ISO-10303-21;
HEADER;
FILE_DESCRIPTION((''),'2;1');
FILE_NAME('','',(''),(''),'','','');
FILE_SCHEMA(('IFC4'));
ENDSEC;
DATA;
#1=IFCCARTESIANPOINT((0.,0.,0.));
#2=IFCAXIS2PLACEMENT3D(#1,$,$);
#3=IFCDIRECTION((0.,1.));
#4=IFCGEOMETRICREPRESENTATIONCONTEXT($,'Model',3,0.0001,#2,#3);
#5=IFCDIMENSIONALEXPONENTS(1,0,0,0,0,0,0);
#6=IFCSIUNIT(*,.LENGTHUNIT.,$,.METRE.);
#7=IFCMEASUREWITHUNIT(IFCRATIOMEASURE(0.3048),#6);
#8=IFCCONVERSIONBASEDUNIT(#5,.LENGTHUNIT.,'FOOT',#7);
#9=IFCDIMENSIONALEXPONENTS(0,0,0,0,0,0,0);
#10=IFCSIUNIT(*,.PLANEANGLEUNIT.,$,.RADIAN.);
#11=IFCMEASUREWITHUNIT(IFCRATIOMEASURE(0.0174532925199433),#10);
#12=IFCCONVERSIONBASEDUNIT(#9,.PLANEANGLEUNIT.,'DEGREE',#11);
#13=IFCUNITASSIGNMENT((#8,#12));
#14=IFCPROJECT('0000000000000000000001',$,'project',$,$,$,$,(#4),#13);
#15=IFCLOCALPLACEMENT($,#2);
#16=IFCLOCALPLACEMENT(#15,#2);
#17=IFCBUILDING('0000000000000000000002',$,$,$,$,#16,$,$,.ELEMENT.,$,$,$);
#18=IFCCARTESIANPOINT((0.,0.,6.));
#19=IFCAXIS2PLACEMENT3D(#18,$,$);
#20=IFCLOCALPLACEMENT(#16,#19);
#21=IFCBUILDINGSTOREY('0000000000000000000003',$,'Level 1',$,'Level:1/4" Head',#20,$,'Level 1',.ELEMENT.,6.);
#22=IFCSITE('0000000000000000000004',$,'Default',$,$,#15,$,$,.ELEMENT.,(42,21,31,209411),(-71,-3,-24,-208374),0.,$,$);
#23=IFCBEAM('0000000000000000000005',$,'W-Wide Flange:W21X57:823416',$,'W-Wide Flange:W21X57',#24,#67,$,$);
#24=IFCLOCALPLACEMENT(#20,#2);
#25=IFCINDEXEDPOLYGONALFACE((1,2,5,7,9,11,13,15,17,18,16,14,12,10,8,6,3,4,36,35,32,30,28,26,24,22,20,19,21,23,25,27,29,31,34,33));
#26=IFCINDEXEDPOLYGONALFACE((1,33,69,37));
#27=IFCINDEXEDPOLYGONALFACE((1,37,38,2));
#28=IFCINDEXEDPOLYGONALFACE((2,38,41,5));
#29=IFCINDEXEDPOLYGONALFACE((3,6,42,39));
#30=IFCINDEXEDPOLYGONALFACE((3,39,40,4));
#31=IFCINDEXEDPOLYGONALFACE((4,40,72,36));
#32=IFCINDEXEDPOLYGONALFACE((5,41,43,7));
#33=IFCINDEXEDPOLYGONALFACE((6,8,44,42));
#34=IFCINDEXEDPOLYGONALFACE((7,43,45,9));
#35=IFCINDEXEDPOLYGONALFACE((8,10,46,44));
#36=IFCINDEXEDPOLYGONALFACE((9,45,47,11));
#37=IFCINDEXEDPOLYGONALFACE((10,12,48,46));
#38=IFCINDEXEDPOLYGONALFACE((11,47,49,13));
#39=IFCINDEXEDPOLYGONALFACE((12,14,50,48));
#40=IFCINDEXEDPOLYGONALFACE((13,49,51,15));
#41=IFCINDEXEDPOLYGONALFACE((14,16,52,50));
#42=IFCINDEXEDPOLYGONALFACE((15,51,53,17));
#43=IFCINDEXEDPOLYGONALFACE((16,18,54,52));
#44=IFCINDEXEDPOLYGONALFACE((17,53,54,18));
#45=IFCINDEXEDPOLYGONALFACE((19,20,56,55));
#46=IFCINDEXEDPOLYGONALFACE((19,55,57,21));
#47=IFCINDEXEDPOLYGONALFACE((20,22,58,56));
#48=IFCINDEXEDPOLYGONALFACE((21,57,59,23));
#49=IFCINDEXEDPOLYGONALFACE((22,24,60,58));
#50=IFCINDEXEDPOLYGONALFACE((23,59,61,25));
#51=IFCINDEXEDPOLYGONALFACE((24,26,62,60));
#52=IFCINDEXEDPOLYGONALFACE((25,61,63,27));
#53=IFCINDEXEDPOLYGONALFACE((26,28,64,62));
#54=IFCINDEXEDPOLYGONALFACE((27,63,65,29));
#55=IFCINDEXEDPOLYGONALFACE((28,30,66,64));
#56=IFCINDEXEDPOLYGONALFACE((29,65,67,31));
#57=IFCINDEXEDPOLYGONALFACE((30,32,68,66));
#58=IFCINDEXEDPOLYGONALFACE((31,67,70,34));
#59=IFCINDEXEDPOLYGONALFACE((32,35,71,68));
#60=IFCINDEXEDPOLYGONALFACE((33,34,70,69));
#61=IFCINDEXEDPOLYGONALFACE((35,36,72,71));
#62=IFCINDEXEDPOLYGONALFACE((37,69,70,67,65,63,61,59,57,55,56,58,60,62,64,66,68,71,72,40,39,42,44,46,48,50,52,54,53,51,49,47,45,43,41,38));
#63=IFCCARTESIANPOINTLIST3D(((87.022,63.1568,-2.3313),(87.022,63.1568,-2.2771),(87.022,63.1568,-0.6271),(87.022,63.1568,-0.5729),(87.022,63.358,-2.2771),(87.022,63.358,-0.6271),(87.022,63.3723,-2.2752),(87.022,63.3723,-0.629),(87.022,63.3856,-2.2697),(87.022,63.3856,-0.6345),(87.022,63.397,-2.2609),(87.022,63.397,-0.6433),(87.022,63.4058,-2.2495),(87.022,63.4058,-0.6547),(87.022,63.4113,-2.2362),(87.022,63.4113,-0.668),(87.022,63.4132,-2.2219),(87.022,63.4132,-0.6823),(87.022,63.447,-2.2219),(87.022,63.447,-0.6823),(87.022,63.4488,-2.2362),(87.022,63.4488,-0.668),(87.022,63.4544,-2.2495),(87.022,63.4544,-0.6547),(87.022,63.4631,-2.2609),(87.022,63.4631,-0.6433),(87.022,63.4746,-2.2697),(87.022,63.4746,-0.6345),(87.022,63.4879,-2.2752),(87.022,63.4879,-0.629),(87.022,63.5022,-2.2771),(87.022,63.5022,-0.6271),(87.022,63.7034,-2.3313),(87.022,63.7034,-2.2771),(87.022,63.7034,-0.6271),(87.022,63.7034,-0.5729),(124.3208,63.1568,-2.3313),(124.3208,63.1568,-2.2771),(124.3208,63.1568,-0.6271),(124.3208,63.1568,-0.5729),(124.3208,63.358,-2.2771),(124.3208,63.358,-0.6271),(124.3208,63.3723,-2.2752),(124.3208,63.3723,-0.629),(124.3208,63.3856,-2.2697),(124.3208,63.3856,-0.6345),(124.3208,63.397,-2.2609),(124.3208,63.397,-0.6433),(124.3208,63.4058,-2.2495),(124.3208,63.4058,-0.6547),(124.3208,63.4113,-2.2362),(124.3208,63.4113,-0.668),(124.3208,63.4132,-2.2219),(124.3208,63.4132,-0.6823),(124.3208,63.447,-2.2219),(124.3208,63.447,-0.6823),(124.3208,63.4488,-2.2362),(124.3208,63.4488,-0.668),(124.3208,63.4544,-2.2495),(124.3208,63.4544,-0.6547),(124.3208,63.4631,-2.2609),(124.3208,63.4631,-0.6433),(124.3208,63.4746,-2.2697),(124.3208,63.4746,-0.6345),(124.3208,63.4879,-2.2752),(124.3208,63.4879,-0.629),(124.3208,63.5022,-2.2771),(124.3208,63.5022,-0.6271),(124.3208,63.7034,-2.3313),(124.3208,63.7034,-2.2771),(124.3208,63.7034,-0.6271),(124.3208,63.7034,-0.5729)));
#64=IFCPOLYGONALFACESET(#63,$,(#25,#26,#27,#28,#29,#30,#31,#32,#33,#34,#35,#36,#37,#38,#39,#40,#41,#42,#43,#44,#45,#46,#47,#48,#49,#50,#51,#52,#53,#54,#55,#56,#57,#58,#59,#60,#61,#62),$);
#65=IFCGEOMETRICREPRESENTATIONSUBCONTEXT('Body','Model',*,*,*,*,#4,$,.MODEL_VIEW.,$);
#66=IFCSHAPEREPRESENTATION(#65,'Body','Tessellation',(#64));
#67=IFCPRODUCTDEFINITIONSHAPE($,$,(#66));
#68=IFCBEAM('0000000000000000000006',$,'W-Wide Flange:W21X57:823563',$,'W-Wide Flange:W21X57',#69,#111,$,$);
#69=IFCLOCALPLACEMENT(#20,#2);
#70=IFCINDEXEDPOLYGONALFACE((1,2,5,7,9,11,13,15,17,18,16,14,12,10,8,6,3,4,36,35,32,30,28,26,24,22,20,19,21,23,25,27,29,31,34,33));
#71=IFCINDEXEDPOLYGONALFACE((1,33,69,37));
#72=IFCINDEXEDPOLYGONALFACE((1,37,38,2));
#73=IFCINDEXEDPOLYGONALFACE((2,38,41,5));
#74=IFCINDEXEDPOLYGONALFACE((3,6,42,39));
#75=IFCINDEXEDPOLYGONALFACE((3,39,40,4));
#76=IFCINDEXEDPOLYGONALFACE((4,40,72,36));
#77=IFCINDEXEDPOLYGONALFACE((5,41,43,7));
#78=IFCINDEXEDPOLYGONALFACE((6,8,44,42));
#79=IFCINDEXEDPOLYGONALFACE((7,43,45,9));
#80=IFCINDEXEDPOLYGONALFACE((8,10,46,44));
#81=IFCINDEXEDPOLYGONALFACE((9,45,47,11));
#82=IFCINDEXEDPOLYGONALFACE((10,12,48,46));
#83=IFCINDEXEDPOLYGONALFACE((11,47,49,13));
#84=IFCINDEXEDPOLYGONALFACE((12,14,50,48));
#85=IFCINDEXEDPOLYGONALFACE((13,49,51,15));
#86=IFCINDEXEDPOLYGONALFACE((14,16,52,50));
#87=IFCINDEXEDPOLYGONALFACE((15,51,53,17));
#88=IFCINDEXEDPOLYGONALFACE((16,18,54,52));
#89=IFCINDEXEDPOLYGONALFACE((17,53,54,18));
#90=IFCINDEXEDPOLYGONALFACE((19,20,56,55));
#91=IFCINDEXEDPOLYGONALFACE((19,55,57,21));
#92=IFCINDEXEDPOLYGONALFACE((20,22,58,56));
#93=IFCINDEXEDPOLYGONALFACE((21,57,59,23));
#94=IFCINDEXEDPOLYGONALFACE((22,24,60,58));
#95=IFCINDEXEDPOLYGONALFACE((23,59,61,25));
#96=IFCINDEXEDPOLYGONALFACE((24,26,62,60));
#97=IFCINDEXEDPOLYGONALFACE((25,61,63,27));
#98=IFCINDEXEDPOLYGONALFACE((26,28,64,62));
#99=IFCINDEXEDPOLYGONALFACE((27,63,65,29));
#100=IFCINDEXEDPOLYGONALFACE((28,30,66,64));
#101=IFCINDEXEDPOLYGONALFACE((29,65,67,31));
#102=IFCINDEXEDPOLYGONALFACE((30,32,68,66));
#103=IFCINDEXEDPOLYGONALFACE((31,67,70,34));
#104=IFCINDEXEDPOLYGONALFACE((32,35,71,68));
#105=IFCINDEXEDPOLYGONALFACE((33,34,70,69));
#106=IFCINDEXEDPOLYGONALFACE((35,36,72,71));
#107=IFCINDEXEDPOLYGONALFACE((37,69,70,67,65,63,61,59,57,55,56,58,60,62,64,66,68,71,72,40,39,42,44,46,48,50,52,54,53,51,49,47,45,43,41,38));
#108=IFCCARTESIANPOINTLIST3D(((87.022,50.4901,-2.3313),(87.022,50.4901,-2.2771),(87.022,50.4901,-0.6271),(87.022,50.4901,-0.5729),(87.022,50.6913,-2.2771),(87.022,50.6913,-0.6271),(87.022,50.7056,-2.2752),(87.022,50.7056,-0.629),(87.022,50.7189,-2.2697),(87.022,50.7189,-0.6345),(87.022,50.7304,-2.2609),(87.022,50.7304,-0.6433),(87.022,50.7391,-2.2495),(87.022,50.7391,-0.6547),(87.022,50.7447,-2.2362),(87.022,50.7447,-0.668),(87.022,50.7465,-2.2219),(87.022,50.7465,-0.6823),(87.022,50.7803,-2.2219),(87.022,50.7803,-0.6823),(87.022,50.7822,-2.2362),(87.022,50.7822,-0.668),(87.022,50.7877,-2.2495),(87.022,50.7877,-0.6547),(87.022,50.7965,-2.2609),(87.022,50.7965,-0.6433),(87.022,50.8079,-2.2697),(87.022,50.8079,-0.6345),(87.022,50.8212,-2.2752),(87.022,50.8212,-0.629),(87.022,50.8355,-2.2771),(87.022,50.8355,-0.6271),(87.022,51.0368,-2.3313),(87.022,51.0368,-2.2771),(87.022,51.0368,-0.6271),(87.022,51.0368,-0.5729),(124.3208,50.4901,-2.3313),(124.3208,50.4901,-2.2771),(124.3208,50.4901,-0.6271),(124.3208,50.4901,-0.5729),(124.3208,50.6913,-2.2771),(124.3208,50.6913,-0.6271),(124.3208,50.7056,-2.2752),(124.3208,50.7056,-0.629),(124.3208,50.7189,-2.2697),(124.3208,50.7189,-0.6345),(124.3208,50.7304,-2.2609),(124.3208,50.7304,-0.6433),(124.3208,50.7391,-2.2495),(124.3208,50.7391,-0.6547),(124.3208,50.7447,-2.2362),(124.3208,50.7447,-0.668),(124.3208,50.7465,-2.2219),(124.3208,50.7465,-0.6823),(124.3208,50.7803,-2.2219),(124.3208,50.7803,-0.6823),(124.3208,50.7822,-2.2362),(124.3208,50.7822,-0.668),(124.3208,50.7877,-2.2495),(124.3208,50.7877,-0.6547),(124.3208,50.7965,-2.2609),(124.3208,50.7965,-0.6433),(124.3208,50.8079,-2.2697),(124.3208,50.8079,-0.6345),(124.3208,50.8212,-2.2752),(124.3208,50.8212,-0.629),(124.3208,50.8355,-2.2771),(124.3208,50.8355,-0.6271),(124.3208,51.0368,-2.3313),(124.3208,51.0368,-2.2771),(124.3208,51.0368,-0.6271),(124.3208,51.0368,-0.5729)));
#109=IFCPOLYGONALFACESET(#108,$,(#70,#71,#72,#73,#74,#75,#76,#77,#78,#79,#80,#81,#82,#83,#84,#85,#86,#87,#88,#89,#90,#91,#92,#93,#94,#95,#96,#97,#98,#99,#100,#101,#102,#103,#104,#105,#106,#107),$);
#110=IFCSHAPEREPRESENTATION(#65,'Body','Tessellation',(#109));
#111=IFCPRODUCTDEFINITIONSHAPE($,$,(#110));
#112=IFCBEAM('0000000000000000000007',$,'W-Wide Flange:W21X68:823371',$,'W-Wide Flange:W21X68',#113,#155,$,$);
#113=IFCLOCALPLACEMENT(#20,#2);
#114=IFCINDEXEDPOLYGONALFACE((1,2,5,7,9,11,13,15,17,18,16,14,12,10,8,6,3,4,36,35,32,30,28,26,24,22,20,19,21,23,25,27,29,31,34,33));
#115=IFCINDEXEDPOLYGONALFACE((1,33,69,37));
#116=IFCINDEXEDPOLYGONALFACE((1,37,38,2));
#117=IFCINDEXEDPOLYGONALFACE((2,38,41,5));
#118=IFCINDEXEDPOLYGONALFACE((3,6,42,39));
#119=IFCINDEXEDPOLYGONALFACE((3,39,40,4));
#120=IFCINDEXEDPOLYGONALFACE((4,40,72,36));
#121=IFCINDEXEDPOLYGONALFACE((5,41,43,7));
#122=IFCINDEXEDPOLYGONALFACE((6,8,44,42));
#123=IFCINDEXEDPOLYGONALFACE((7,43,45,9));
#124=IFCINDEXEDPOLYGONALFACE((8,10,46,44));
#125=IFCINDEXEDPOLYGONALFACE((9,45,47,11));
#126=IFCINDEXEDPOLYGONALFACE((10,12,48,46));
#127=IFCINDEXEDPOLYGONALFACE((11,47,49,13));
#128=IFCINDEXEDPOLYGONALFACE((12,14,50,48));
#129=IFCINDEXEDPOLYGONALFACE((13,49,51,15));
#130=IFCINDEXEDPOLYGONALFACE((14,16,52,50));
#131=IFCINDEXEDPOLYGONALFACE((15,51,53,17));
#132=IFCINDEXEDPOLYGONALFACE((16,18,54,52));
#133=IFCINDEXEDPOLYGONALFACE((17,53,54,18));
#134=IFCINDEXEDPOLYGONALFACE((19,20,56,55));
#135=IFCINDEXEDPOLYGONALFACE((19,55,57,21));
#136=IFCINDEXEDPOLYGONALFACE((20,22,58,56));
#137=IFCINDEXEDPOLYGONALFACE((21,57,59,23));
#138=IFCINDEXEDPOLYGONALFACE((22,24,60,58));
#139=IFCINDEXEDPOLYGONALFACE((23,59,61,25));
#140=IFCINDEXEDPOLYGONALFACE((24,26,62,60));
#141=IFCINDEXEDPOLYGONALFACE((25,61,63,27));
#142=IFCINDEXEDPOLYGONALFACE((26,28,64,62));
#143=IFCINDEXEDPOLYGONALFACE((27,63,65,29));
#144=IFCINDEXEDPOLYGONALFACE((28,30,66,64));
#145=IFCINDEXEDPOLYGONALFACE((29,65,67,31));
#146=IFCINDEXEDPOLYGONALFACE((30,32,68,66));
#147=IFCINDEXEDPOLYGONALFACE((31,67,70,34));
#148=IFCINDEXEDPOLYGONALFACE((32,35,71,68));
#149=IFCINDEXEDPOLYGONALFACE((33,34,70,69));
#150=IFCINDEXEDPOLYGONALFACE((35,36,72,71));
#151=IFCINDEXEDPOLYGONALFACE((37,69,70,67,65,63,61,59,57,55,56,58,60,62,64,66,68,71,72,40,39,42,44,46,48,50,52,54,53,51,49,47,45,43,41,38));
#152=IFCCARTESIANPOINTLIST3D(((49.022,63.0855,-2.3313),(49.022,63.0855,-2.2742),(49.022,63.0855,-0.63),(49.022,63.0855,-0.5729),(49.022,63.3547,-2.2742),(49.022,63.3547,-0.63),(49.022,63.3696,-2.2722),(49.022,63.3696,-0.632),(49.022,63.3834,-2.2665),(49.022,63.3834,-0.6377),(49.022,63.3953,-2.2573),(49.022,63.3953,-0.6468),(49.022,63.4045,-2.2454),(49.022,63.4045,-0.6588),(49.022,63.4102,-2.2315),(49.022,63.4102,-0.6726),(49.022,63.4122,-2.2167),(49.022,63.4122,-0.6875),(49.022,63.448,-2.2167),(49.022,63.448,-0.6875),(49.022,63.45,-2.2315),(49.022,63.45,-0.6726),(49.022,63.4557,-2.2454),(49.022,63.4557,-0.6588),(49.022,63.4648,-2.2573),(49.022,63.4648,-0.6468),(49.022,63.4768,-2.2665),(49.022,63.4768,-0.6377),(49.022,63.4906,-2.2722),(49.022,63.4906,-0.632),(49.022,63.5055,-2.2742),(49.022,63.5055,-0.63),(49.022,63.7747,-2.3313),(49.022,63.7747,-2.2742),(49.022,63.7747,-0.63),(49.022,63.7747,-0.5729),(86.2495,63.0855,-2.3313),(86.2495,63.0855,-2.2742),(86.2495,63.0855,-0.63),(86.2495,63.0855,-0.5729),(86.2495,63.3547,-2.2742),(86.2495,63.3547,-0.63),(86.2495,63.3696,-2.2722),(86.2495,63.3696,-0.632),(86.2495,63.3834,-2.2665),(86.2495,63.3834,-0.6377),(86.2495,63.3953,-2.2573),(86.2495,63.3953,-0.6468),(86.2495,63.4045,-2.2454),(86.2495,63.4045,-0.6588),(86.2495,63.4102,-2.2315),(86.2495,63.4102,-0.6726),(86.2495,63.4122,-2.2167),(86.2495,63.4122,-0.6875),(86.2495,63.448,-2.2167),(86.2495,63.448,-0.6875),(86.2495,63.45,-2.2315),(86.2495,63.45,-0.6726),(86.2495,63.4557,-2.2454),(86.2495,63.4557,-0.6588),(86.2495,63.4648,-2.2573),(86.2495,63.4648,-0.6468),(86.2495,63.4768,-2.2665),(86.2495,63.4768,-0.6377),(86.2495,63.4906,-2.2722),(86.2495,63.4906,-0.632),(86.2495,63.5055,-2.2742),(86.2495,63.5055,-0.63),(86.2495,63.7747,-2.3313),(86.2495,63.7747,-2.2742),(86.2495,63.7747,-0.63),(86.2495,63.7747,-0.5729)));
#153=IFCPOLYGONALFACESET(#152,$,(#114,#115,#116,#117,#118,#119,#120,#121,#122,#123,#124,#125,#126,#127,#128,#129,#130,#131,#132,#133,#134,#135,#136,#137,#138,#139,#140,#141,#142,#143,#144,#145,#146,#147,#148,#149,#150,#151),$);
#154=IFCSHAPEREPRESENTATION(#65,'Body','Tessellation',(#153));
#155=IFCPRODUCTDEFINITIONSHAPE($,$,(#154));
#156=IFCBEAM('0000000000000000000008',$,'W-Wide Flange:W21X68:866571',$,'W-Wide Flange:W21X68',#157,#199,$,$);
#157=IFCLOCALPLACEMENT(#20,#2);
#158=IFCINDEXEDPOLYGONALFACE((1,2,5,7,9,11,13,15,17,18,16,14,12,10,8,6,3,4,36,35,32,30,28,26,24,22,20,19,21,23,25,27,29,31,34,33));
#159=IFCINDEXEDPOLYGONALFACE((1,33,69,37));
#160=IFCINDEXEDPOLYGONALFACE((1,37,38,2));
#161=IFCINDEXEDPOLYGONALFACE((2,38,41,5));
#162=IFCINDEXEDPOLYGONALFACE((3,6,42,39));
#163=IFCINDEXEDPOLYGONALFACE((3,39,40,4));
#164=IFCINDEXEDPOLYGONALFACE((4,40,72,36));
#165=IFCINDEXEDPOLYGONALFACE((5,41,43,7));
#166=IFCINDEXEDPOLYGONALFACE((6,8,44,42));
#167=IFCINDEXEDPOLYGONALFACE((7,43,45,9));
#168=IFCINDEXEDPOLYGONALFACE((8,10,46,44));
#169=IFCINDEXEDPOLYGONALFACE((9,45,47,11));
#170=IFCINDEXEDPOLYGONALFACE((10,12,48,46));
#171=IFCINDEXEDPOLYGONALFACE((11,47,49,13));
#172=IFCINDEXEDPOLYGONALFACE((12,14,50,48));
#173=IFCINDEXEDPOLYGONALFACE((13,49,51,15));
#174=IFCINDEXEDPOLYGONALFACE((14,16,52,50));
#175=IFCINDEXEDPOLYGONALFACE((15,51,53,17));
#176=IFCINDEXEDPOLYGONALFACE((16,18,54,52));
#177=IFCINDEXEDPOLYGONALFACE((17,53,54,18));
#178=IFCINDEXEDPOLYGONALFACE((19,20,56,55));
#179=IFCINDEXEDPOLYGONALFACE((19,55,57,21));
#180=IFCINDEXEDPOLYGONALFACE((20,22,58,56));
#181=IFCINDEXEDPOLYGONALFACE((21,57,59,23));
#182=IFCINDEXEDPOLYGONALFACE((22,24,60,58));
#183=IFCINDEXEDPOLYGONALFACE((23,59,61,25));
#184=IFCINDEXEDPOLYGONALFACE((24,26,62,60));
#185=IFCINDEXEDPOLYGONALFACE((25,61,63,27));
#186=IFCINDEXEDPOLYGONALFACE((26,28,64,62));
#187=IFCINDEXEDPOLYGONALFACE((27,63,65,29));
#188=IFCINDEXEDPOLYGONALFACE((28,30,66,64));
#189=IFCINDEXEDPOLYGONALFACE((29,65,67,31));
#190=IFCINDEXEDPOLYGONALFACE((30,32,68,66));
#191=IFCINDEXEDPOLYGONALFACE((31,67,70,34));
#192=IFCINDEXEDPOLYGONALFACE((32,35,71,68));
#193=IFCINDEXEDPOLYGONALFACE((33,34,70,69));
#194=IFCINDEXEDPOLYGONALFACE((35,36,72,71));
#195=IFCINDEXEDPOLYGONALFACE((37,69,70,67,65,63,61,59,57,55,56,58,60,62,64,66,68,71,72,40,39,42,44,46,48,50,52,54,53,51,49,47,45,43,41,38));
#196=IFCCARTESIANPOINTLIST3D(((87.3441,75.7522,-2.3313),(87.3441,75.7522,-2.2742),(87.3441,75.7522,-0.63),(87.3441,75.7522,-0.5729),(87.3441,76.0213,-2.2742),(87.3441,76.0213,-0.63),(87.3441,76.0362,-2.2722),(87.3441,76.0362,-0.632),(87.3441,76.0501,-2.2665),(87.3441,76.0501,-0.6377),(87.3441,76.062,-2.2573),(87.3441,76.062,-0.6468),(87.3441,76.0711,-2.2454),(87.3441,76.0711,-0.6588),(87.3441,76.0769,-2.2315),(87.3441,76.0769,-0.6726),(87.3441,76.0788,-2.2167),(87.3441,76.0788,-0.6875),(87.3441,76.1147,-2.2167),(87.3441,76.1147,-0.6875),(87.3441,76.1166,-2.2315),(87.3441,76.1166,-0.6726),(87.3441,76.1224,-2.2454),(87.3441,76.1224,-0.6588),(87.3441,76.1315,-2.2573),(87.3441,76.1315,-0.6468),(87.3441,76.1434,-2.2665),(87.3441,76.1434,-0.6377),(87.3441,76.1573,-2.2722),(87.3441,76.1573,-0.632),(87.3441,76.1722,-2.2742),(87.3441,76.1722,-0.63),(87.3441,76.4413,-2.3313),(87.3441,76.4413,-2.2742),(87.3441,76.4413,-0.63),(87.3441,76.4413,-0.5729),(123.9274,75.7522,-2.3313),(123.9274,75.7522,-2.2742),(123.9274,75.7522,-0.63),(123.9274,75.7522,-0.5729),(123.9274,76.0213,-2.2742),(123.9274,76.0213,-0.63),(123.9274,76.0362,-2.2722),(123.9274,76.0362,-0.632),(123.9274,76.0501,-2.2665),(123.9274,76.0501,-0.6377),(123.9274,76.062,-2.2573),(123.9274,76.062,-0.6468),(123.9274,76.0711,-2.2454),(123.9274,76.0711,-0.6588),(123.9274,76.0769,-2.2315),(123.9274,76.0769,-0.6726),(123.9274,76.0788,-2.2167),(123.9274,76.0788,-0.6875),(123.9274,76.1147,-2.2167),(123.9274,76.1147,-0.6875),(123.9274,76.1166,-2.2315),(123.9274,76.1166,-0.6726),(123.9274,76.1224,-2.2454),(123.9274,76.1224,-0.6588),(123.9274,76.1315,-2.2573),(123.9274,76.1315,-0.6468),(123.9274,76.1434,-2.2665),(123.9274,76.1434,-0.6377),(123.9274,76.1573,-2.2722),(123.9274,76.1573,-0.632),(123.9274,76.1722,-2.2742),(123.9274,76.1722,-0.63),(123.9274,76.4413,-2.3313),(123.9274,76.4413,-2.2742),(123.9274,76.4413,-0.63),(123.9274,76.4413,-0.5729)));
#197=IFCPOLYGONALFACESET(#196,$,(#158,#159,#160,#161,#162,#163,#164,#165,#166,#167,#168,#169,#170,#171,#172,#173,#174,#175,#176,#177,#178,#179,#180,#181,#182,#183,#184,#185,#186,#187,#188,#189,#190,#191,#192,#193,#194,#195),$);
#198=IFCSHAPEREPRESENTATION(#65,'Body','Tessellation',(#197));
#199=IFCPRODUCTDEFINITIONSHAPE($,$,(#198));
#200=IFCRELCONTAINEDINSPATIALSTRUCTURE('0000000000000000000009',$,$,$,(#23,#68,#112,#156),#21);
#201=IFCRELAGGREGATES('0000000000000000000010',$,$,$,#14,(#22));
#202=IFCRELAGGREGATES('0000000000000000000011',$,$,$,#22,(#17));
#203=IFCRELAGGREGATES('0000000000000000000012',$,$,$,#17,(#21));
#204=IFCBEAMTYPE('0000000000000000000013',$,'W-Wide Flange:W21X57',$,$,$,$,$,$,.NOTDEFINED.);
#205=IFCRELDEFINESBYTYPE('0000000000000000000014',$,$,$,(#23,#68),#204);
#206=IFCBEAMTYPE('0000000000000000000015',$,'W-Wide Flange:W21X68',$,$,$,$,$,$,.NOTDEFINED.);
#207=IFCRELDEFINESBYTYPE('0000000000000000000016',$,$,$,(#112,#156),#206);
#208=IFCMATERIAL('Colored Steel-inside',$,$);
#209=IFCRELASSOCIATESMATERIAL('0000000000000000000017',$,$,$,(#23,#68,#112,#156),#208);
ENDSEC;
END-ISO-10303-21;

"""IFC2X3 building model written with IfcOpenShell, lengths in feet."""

from ifc_helpers import new_model, entity, si_unit, converted_unit, direction, frame, frame_2d, origin, place, context, subcontext, project, spatial, i_section, extrude, material, type_object, element, save


model = new_model("IFC2X3")

# Units and contexts
model_context = context("Model", 3, precision=0.0001, world=origin(), true_north=direction((0.0, 1.0)))
body_context = subcontext(model_context, "Body", "Model", "MODEL_VIEW")
ifc_project = project(units=[converted_unit("LENGTHUNIT", "FOOT", entity("IfcRatioMeasure", 0.3048), si_unit("LENGTHUNIT", "METRE"), dimensions=[1, 0, 0, 0, 0, 0, 0]), converted_unit("PLANEANGLEUNIT", "DEGREE", entity("IfcRatioMeasure", 0.0174532925199433), si_unit("PLANEANGLEUNIT", "RADIAN"), dimensions=[0, 0, 0, 0, 0, 0, 0])], contexts=[model_context])

# Site, building, storey
site_placement = place(None, origin())
site = spatial("IfcSite", under=ifc_project, at=site_placement, Name="Default", CompositionType="ELEMENT", RefLatitude=(42, 21, 31, 209411), RefLongitude=(-71, -3, -24, -208374), RefElevation=0.0)
building_placement = place(site_placement, origin())
building = spatial("IfcBuilding", under=site, at=building_placement, CompositionType="ELEMENT")
storey_placement = place(building_placement, frame((0.0, 0.0, 6.0)))
storey = spatial("IfcBuildingStorey", under=building, at=storey_placement, Name="Level 1", ObjectType="Level:1/4\" Head", LongName="Level 1", CompositionType="ELEMENT", Elevation=6.0)

# Shared definitions
ifc_material_1 = material(Name="Colored Steel-inside")

# Beams
beam_type_1 = type_object("IfcBeamType", Name="W-Wide Flange:W21X57", PredefinedType="NOTDEFINED")
beam_1_placement = place(storey_placement, frame((86.6554, 63.4301, 0.0)))
element("IfcBeam", 1, at=beam_1_placement, inside=storey, type_object=beam_type_1, material=ifc_material_1, Name="W-Wide Flange:W21X57:823416", ObjectType="W-Wide Flange:W21X57", context=body_context, shape_type="SweptSolid", body=[
    extrude(i_section(OverallWidth=0.5467, OverallDepth=1.7583, WebThickness=0.0337, FlangeThickness=0.0542, FilletRadius=0.0552, at=frame_2d((0.0, 0.0), x_axis=(0.0, 1.0))), frame((0.3667, 0.0, -1.4521), z_axis=(1.0, 0.0, 0.0), x_axis=(0.0, 0.0, -1.0)), (0.0, 0.0, 1.0), 37.2987),
])
beam_2_placement = place(storey_placement, frame((86.6554, 50.7634, 0.0)))
element("IfcBeam", 2, at=beam_2_placement, inside=storey, type_object=beam_type_1, material=ifc_material_1, Name="W-Wide Flange:W21X57:823563", ObjectType="W-Wide Flange:W21X57", context=body_context, shape_type="SweptSolid", body=[
    extrude(i_section(OverallWidth=0.5467, OverallDepth=1.7583, WebThickness=0.0337, FlangeThickness=0.0542, FilletRadius=0.0552, at=frame_2d((0.0, 0.0), x_axis=(0.0, 1.0))), frame((0.3667, 0.0, -1.4521), z_axis=(1.0, 0.0, 0.0), x_axis=(0.0, 0.0, -1.0)), (0.0, 0.0, 1.0), 37.2987),
])
beam_type_2 = type_object("IfcBeamType", Name="W-Wide Flange:W21X68", PredefinedType="NOTDEFINED")
beam_3_placement = place(storey_placement, frame((48.6225, 63.4301, 0.0)))
element("IfcBeam", 3, at=beam_3_placement, inside=storey, type_object=beam_type_2, material=ifc_material_1, Name="W-Wide Flange:W21X68:823371", ObjectType="W-Wide Flange:W21X68", context=body_context, shape_type="SweptSolid", body=[
    extrude(i_section(OverallWidth=0.6892, OverallDepth=1.7583, WebThickness=0.0358, FlangeThickness=0.0571, FilletRadius=0.0575, at=frame_2d((0.0, 0.0), x_axis=(0.0, 1.0))), frame((0.3995, 0.0, -1.4521), z_axis=(1.0, 0.0, 0.0), x_axis=(0.0, 0.0, -1.0)), (0.0, 0.0, 1.0), 37.2275),
])
beam_4_placement = place(storey_placement, frame((86.6554, 76.0968, 0.0)))
element("IfcBeam", 4, at=beam_4_placement, inside=storey, type_object=beam_type_2, material=ifc_material_1, Name="W-Wide Flange:W21X68:866571", ObjectType="W-Wide Flange:W21X68", context=body_context, shape_type="SweptSolid", body=[
    extrude(i_section(OverallWidth=0.6892, OverallDepth=1.7583, WebThickness=0.0358, FlangeThickness=0.0571, FilletRadius=0.0575, at=frame_2d((0.0, 0.0), x_axis=(0.0, 1.0))), frame((0.6888, 0.0, -1.4521), z_axis=(1.0, 0.0, 0.0), x_axis=(0.0, 0.0, -1.0)), (0.0, 0.0, 1.0), 36.5833),
])

save(model, "model.ifc")
